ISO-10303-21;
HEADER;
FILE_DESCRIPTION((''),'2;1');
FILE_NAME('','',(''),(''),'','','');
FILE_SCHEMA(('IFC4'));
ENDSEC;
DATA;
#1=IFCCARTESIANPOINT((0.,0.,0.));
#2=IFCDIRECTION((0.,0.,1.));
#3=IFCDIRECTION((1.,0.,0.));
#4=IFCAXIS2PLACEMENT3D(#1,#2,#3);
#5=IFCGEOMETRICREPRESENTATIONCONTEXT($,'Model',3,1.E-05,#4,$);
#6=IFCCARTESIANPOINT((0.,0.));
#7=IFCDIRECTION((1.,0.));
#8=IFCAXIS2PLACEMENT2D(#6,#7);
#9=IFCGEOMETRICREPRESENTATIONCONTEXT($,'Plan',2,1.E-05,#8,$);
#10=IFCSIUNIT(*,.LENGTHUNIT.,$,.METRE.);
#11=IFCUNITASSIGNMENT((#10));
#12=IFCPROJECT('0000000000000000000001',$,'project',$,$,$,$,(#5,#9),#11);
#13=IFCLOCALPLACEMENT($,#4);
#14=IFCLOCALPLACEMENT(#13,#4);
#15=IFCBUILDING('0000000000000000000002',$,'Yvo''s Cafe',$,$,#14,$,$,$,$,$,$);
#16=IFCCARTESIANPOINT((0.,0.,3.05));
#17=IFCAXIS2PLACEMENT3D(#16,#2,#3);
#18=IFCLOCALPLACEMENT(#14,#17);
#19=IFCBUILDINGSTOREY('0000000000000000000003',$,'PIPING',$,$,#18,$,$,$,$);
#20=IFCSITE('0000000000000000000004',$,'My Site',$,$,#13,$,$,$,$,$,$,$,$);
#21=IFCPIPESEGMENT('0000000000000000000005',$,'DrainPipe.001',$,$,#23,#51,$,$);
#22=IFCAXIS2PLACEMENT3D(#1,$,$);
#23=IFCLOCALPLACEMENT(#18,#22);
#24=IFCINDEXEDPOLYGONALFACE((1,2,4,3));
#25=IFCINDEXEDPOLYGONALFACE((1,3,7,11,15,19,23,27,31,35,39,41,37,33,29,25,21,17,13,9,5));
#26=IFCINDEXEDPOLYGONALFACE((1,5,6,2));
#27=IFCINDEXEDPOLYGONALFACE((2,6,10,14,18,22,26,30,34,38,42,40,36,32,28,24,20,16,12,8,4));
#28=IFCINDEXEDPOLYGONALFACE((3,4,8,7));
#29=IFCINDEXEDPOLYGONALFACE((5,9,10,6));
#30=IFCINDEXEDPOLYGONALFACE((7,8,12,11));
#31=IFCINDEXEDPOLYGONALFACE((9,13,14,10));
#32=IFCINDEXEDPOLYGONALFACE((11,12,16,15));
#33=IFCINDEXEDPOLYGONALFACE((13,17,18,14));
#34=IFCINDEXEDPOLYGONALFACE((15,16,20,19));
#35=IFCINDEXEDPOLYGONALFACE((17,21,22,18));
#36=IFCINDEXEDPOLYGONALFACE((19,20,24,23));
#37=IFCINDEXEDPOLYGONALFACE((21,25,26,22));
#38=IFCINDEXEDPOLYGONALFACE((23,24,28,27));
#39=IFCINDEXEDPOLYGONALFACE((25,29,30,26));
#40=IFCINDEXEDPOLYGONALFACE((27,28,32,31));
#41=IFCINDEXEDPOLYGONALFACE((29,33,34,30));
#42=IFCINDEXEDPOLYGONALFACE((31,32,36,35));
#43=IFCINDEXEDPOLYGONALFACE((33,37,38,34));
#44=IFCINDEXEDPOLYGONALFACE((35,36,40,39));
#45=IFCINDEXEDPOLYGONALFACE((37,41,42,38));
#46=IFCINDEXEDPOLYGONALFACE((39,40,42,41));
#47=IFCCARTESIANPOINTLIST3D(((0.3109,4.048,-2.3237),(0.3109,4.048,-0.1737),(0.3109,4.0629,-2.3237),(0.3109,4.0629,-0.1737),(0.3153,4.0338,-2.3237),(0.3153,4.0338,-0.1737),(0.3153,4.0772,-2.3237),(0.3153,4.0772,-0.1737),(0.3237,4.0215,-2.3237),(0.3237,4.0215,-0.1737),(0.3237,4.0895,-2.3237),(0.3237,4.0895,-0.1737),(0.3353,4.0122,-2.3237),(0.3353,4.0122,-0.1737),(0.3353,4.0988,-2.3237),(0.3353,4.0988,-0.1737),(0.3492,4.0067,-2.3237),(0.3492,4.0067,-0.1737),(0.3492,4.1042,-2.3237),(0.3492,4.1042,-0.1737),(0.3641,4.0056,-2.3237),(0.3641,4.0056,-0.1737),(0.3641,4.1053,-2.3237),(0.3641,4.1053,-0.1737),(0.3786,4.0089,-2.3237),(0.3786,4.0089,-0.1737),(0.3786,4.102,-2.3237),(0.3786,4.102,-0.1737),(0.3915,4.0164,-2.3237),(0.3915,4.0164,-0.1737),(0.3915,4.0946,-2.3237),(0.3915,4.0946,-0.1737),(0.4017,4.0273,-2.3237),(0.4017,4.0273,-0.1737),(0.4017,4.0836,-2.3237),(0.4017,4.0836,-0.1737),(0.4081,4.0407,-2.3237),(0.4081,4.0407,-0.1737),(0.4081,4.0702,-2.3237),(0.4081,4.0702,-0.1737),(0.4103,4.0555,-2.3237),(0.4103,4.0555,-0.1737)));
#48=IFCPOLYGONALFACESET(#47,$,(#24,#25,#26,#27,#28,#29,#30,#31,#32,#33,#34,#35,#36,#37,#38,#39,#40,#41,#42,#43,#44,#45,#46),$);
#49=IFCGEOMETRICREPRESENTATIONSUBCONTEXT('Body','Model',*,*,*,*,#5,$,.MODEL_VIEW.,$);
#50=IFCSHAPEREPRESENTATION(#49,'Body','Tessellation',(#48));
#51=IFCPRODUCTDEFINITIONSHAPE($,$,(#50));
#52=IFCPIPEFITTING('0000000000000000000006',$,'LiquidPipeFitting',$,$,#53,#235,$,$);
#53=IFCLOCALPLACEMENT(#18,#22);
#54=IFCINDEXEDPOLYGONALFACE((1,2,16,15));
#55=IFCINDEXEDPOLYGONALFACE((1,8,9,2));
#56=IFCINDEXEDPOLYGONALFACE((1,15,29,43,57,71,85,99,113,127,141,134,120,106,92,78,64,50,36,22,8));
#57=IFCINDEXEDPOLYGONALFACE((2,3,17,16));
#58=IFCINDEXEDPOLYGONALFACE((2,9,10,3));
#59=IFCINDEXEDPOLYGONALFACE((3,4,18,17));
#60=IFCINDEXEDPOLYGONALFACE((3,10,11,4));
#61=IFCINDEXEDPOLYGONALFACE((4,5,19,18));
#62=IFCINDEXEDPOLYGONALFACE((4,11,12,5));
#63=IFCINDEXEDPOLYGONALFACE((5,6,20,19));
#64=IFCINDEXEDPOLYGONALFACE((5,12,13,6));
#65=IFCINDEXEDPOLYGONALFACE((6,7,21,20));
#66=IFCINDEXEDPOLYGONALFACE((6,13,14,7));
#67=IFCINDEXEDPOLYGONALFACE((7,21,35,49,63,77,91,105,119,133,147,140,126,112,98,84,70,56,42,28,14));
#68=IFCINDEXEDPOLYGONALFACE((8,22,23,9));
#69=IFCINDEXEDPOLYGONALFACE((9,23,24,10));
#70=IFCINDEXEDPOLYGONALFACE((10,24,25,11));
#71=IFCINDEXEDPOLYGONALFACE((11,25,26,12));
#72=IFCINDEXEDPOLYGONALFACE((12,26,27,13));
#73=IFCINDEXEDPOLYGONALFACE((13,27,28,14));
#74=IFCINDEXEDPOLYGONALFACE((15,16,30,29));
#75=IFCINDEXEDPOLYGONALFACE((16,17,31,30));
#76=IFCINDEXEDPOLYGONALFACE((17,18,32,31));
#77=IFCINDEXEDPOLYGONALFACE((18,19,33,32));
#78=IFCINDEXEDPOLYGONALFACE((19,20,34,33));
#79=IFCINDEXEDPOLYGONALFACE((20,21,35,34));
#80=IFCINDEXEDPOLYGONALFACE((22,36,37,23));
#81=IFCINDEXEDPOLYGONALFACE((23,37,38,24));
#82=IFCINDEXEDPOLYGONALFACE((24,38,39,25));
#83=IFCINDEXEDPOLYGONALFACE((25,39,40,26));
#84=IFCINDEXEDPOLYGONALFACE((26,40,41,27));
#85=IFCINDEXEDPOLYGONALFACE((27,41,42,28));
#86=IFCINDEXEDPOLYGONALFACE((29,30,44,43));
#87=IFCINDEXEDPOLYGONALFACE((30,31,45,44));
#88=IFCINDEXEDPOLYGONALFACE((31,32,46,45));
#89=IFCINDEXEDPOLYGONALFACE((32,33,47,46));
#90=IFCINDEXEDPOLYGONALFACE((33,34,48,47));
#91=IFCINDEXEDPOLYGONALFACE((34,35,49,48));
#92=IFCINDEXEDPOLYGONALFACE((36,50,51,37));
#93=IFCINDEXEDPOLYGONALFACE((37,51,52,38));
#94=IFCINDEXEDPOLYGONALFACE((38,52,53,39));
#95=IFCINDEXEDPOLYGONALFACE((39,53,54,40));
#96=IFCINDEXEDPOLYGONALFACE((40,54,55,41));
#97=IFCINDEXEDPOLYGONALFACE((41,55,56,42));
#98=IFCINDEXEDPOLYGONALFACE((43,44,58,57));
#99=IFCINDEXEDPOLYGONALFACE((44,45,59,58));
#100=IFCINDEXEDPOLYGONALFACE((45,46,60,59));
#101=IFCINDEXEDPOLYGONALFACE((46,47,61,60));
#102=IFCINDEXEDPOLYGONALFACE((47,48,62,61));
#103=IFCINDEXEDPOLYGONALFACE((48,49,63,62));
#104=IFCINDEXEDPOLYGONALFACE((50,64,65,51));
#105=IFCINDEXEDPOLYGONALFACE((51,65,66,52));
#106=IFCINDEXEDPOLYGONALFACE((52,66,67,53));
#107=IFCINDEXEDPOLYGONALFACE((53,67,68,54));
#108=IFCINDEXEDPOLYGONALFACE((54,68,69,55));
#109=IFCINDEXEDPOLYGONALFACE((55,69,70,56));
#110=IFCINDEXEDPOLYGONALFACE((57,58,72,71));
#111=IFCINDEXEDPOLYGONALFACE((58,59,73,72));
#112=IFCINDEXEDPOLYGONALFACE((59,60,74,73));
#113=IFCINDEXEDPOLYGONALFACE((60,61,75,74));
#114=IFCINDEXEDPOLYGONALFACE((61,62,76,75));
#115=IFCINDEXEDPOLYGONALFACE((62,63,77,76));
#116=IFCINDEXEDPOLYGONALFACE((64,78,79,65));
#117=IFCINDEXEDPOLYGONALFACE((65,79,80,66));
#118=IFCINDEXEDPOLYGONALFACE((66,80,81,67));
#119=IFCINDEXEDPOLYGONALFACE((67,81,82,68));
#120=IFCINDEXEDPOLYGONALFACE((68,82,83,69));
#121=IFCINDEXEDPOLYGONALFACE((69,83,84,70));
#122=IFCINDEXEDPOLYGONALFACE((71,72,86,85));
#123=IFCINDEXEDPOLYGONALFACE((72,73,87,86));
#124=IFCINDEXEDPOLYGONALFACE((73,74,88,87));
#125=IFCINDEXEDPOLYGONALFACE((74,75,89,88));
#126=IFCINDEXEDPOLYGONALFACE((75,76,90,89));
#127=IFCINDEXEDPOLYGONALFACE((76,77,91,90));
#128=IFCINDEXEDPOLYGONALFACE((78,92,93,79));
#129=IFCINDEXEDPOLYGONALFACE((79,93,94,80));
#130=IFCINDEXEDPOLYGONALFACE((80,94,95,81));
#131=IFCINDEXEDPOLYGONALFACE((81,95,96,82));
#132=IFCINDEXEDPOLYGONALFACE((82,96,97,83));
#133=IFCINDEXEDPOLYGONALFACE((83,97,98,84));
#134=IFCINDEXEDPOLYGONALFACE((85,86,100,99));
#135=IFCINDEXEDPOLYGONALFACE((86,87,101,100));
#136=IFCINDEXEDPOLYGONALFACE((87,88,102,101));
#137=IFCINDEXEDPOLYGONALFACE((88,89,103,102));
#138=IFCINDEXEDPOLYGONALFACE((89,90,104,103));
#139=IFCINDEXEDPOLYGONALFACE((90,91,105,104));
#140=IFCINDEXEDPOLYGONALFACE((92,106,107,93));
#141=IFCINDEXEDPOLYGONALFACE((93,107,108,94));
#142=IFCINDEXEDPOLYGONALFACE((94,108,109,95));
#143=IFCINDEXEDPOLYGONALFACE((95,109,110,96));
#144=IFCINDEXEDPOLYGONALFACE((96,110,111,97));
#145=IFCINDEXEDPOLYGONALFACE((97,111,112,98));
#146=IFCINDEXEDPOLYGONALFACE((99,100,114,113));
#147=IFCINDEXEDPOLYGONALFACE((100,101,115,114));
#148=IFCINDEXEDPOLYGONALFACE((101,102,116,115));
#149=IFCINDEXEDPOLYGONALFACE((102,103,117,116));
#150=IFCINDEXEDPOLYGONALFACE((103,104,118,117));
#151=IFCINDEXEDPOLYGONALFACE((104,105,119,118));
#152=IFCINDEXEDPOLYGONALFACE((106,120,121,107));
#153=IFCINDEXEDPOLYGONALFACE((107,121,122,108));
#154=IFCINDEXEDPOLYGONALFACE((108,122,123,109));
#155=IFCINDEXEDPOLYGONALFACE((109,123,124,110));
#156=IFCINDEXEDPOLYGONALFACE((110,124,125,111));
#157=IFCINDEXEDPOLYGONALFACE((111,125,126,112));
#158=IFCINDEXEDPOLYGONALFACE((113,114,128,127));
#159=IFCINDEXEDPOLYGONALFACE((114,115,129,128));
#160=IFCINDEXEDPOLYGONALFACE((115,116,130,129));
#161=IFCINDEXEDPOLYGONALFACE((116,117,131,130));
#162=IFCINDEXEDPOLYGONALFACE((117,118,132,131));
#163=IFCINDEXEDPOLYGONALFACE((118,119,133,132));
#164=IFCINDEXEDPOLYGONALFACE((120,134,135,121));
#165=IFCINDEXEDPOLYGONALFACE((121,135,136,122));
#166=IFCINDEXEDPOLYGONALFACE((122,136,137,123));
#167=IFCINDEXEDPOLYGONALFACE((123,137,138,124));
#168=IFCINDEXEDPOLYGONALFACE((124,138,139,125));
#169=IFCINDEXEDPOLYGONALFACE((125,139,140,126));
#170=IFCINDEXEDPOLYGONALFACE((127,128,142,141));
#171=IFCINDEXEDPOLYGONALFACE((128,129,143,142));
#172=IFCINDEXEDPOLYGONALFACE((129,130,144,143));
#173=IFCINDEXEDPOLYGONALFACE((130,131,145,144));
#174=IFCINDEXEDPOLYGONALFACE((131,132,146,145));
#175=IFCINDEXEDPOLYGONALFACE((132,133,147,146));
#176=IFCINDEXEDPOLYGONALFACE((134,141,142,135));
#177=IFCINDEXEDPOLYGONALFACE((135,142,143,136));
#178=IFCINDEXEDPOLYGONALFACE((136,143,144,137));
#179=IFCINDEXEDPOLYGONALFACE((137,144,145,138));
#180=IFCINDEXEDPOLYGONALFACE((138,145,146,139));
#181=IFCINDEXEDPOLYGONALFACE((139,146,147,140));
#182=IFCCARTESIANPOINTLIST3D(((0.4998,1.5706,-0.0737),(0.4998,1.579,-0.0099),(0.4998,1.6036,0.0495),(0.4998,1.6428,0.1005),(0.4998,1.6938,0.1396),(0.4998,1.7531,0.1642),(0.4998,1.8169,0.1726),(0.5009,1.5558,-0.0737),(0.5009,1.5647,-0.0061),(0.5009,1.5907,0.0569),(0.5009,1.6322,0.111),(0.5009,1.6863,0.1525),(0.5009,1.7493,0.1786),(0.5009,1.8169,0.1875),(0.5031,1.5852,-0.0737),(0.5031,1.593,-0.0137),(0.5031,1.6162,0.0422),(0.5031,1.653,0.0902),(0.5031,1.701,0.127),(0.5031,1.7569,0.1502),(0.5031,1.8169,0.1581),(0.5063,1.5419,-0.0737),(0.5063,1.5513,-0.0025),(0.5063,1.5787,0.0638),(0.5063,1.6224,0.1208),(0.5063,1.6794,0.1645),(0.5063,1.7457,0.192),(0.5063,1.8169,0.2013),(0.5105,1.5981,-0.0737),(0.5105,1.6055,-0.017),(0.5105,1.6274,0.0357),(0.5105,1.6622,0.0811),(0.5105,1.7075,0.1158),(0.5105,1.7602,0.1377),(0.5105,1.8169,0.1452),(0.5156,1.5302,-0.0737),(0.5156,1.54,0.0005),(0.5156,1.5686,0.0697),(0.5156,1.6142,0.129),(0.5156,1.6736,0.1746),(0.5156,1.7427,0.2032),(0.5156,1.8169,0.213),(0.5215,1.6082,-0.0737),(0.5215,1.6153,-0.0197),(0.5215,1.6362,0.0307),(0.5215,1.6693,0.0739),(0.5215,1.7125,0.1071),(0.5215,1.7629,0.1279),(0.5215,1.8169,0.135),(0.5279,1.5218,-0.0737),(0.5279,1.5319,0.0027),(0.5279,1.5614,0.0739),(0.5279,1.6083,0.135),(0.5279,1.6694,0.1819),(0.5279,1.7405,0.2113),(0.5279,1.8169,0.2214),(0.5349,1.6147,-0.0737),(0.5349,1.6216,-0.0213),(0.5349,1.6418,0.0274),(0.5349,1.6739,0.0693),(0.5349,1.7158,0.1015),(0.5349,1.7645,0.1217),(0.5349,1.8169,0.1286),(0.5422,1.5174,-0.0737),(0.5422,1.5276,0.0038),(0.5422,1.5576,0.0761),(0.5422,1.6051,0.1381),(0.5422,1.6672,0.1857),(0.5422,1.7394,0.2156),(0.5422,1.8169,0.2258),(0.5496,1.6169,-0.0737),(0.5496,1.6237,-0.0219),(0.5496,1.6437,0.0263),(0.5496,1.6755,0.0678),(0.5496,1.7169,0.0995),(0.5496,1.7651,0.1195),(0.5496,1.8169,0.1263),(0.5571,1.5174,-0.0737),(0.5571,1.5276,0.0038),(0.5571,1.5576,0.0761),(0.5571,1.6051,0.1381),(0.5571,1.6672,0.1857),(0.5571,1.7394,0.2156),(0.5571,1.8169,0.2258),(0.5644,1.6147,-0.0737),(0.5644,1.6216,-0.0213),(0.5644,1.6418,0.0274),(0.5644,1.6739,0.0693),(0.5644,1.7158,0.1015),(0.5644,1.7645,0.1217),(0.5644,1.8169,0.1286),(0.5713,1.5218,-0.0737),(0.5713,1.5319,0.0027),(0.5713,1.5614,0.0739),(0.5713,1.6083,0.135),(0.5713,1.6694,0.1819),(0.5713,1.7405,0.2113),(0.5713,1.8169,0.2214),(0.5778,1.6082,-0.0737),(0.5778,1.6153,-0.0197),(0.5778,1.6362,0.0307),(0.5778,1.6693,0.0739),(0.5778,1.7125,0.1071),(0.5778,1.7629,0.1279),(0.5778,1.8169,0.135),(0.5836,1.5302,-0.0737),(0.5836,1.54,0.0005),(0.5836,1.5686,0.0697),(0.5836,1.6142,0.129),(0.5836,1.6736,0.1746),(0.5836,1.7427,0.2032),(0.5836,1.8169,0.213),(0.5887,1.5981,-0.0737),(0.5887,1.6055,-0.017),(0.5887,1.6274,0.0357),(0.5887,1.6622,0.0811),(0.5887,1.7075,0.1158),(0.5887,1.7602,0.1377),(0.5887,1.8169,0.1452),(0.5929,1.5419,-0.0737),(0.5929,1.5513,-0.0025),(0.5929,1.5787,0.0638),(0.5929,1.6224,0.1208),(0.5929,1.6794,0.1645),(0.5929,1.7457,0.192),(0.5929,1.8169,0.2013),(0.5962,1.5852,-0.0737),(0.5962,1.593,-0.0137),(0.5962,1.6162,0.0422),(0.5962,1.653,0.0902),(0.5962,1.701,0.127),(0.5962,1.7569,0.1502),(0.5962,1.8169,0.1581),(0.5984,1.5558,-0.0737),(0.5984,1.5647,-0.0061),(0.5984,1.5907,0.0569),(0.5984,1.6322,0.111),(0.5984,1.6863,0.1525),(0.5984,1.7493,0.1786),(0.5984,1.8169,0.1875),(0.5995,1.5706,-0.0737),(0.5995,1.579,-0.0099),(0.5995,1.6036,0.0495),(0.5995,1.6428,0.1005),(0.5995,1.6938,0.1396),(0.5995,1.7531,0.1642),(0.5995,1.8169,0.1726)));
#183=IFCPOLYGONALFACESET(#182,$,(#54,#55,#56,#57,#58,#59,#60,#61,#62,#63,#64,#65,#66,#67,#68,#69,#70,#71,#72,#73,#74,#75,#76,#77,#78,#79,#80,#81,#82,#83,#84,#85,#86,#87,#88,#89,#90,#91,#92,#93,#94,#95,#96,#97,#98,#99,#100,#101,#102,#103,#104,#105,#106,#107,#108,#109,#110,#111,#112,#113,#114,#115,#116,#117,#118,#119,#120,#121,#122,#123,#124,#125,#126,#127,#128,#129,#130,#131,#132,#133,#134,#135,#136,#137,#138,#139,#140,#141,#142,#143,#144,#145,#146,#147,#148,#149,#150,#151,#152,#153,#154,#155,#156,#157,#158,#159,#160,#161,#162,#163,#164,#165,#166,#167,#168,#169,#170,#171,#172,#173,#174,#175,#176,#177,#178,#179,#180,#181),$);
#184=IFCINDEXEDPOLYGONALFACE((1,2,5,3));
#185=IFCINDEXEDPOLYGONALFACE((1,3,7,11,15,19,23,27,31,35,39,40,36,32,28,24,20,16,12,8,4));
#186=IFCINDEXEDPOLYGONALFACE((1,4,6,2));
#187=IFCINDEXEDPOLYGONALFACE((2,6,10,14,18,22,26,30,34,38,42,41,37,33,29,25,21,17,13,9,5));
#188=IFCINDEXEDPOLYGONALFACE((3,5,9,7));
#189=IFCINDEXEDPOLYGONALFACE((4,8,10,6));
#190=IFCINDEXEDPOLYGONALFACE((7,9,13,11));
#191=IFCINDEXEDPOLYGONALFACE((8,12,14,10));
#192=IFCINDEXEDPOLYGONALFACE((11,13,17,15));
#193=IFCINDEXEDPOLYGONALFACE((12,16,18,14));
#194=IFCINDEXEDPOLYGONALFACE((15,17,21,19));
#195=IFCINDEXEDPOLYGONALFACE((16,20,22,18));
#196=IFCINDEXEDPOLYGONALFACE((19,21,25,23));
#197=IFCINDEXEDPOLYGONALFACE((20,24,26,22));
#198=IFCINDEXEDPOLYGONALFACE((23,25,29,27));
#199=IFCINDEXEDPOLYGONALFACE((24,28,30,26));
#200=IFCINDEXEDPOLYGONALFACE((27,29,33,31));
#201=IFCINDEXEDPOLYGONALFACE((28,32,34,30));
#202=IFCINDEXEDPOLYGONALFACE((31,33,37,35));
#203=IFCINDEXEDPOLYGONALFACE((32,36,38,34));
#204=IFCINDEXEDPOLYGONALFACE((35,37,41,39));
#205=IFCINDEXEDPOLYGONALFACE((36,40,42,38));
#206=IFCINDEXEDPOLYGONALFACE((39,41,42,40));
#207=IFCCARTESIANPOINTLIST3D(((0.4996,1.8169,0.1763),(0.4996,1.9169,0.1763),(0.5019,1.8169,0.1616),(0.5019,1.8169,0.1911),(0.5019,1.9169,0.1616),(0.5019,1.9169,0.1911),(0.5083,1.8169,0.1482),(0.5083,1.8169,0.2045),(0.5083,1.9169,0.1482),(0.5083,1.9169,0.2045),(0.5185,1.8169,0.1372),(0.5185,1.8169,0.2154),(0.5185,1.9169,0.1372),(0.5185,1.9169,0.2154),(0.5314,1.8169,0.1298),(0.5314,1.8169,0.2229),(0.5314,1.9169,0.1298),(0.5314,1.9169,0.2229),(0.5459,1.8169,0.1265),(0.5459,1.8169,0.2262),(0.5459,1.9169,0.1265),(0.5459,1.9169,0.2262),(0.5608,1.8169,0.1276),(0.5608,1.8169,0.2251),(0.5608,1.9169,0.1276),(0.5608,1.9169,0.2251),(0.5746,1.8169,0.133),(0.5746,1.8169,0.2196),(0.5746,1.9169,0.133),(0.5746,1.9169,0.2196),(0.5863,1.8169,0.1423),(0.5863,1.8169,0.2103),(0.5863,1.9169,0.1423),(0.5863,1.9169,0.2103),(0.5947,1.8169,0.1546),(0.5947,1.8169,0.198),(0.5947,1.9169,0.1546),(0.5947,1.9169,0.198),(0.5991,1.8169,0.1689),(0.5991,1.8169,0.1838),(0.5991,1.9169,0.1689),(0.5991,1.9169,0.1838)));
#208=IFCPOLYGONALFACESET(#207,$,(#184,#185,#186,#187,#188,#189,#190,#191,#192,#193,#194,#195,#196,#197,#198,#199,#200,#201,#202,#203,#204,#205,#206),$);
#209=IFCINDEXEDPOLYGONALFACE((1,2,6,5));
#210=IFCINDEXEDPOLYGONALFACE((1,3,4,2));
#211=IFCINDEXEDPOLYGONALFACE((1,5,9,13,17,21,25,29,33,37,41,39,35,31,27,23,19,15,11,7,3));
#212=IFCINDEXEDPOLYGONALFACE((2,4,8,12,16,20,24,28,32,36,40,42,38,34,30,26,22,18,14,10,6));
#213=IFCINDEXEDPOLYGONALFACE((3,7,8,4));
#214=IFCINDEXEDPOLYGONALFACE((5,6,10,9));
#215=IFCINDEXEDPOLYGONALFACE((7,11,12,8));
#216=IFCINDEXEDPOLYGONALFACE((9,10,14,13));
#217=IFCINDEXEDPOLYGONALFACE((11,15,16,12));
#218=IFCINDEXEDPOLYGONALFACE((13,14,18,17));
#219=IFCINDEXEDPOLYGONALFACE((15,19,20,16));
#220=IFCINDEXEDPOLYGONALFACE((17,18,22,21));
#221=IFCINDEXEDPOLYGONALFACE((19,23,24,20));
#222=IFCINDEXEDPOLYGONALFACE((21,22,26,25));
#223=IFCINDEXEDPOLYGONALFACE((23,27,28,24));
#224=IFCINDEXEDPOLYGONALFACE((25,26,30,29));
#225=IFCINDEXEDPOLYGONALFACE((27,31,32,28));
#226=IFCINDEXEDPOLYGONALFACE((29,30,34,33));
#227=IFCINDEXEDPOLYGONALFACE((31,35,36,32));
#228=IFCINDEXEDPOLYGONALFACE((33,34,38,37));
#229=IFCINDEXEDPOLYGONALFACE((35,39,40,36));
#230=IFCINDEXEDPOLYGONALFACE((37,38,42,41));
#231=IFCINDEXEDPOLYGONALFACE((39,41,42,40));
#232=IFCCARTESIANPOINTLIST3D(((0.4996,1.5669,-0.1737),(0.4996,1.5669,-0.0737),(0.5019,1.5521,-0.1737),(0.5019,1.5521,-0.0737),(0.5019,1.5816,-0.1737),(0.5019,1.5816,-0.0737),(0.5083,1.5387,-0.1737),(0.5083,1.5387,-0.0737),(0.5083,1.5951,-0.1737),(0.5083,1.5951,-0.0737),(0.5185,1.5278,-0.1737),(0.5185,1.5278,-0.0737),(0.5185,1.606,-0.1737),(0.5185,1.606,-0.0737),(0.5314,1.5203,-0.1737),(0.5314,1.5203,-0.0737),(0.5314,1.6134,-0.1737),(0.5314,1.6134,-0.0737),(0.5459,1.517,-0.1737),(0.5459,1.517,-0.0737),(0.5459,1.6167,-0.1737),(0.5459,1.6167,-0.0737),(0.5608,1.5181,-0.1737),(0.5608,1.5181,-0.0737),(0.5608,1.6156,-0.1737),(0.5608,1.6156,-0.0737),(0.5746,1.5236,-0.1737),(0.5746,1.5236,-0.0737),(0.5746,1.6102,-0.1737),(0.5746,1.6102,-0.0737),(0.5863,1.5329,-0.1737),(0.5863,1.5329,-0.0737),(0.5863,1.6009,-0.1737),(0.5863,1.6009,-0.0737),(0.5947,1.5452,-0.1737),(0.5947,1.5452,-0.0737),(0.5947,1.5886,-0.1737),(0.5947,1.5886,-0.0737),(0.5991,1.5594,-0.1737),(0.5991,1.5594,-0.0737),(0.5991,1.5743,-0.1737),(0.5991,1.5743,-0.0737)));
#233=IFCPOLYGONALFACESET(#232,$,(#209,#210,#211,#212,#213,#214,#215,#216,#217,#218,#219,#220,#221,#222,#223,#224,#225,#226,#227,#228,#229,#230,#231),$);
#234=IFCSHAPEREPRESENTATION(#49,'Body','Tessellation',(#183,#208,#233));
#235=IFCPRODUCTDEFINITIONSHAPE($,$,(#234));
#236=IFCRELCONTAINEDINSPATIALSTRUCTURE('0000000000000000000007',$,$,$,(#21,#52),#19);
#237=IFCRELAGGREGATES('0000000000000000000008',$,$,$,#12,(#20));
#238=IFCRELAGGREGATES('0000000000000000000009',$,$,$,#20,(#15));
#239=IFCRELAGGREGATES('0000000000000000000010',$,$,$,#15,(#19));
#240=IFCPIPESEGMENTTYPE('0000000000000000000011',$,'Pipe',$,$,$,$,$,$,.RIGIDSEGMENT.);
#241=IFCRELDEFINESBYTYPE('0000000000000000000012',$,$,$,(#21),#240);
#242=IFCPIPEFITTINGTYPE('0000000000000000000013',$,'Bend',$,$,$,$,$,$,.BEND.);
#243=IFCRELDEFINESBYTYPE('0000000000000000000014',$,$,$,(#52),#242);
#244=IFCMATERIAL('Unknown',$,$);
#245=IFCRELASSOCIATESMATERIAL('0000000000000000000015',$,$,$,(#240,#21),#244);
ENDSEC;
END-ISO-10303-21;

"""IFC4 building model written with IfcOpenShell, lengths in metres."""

from ifc_helpers import new_model, entity, si_unit, frame, origin_with_axes, origin_2d_with_axis, place, context, subcontext, project, spatial, circle, extrude, source, transform, mapped, material, material_profile, profile_set, profile_usage, type_object, type_shapes, element, save


model = new_model("IFC4")

# Units and contexts
model_context = context("Model", 3, precision=1e-05, world=origin_with_axes())
plan_context = context("Plan", 2, precision=1e-05, world=origin_2d_with_axis())
body_context = subcontext(model_context, "Body", "Model", "MODEL_VIEW")
ifc_project = project(units=[si_unit("LENGTHUNIT", "METRE")], contexts=[model_context, plan_context])

# Site, building, storey
site_placement = place(None, origin_with_axes())
site = spatial("IfcSite", under=ifc_project, at=site_placement, Name="My Site")
building_placement = place(site_placement, origin_with_axes())
building = spatial("IfcBuilding", under=site, at=building_placement, Name="Yvo's Cafe")
storey_placement = place(building_placement, frame((0.0, 0.0, 3.05), z_axis=(0.0, 0.0, 1.0), x_axis=(1.0, 0.0, 0.0)))
storey = spatial("IfcBuildingStorey", under=building, at=storey_placement, Name="PIPING")

# Pipe segment
ifc_material = material(Name="Unknown")
ifc_material_profile = material_profile(ifc_material, circle(Radius=0.05))
ifc_profile_set = profile_set([ifc_material_profile])
pipe_segment_type = type_object("IfcPipeSegmentType", Name="Pipe", PredefinedType="RIGIDSEGMENT", material=ifc_profile_set)
ifc_profile_usage_1 = profile_usage(ifc_profile_set, cardinal=5)
pipe_segment_1_placement = place(storey_placement, frame((0.3603, 4.0555, -0.1737), z_axis=(0.0, 0.0, -1.0), x_axis=(1.0, 0.0, 0.0)))
element("IfcPipeSegment", 1, at=pipe_segment_1_placement, inside=storey, type_object=pipe_segment_type, material=ifc_profile_usage_1, Name="DrainPipe.001", context=body_context, shape_type="SweptSolid", body=[
    extrude(circle(Radius=0.05), origin_with_axes(), (0.0, 0.0, 1.0), 2.15),
])

# Pipe fitting
pipe_fitting_type_1 = type_object("IfcPipeFittingType", Name="Bend", PredefinedType="BEND")
shared_shape_1 = source(origin_with_axes(), body_context, "Body", "SolidModel", [
    entity("IfcSweptDiskSolid", entity("IfcIndexedPolyCurve", entity("IfcCartesianPointList3D", [[0.0, 0.0, -0.1], [0.0, -0.0732, -0.2768], [0.0, -0.25, -0.35]]), [entity("IfcArcIndex", [1, 2, 3])]), 0.05),
    extrude(circle(Radius=0.05), origin_with_axes(), (0.0, 0.0, -1.0), 0.1),
    extrude(circle(Radius=0.05), frame((0.0, -0.25, -0.35), z_axis=(0.0, -1.0, 0.0), x_axis=(1.0, 0.0, 0.0)), (0.0, 0.0, 1.0), 0.1),
])
type_shapes(pipe_fitting_type_1, [shared_shape_1])
pipe_fitting_1_placement = place(storey_placement, frame((0.5496, 1.9169, 0.1763), z_axis=(0.0, 1.0, 0.0), x_axis=(-1.0, 0.0, 0.0)))
element("IfcPipeFitting", 2, at=pipe_fitting_1_placement, inside=storey, type_object=pipe_fitting_type_1, Name="LiquidPipeFitting", context=body_context, shape_type="MappedRepresentation", body=[
    mapped(shared_shape_1, transform((0.0, 0.0, 0.0), x_axis=(1.0, 0.0, 0.0), y_axis=(0.0, 1.0, 0.0), z_axis=(0.0, 0.0, 1.0), scale=1.0)),
])

save(model, "model.ifc")
